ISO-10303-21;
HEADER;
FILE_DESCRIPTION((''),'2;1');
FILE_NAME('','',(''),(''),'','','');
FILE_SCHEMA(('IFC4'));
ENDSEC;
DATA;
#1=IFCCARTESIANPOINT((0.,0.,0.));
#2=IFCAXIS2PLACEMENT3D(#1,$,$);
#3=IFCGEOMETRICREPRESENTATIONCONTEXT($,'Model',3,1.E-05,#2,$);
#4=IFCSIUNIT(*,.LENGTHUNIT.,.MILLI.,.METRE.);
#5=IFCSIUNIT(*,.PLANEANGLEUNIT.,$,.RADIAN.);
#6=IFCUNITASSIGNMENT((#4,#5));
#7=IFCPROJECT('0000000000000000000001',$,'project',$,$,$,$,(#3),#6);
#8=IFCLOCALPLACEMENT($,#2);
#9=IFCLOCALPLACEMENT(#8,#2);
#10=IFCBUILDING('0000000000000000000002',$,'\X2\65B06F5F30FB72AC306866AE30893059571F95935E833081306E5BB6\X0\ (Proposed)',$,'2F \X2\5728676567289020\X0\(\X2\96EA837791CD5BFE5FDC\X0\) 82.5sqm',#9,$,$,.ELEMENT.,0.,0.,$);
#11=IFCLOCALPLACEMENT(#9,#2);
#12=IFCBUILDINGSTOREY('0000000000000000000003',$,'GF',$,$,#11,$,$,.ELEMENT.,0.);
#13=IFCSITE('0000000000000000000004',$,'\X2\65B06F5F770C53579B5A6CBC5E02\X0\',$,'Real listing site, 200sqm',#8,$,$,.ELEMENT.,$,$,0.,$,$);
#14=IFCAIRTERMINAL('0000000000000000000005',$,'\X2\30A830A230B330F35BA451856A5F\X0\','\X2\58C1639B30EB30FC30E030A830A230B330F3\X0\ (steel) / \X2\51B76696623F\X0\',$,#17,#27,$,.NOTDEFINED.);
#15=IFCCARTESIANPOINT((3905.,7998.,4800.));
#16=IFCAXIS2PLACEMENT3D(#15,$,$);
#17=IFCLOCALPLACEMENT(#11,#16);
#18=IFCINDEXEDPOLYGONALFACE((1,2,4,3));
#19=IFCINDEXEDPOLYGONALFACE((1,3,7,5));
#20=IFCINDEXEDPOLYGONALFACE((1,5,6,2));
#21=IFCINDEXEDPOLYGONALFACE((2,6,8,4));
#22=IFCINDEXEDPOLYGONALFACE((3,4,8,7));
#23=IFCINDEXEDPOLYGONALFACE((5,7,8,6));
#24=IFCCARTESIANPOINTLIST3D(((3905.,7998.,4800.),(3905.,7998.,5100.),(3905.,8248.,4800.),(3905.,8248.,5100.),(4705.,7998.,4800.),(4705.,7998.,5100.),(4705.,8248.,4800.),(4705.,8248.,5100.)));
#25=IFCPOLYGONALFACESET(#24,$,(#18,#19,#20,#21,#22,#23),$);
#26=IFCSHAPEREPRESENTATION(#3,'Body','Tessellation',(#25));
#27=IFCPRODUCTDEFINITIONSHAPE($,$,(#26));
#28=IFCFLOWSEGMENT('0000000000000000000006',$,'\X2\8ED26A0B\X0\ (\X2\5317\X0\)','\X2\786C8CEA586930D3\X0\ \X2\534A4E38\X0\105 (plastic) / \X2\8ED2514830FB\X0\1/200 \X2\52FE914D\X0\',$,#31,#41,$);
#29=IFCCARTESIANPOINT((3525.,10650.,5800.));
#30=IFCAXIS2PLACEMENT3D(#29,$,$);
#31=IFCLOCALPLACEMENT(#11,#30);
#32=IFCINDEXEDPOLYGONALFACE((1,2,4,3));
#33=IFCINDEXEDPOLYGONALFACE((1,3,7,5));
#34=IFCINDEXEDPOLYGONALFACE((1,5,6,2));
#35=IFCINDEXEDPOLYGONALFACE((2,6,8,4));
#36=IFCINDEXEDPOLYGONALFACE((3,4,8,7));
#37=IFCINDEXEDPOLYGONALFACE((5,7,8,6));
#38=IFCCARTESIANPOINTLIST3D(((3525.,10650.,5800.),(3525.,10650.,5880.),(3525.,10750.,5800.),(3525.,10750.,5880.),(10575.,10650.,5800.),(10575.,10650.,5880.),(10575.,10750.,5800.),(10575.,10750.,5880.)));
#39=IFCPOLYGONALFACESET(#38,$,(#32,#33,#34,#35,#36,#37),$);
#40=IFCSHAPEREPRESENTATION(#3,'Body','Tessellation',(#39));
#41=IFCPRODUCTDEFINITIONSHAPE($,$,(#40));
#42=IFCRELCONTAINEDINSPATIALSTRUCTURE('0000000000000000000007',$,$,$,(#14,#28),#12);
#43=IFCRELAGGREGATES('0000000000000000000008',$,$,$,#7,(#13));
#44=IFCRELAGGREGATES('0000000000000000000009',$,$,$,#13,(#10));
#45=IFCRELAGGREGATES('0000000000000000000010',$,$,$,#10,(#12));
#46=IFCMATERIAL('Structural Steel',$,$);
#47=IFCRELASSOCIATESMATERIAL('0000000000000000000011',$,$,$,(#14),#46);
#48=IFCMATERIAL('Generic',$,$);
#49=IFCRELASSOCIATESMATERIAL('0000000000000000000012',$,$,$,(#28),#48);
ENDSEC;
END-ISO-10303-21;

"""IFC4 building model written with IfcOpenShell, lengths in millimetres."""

from ifc_helpers import new_model, si_unit, frame, frame_2d, origin, place, context, project, spatial, rectangle, extrude, material, element, save


model = new_model("IFC4")

# Units and contexts
model_context = context("Model", 3, precision=1e-05, world=origin())
ifc_project = project(units=[si_unit("LENGTHUNIT", "METRE", prefix="MILLI"), si_unit("PLANEANGLEUNIT", "RADIAN")], contexts=[model_context])

# Site, building, storey
site_placement = place(None, origin())
site = spatial("IfcSite", under=ifc_project, at=site_placement, Name="新潟県南魚沼市", ObjectType="Real listing site, 200sqm", CompositionType="ELEMENT", RefElevation=0.0)
building_placement = place(site_placement, origin())
building = spatial("IfcBuilding", under=site, at=building_placement, Name="新潟・犬と暮らす土間広めの家 (Proposed)", ObjectType="2F 在来木造(雪荷重対応) 82.5sqm", CompositionType="ELEMENT", ElevationOfRefHeight=0.0, ElevationOfTerrain=0.0)
storey_placement = place(building_placement, origin())
storey = spatial("IfcBuildingStorey", under=building, at=storey_placement, Name="GF", CompositionType="ELEMENT", Elevation=0.0)

# Shared definitions
ifc_material_1 = material(Name="Structural Steel")

# Shared definitions
ifc_material_2 = material(Name="Generic")

# Air terminal
air_terminal_placement = place(storey_placement, frame((3905.0, 7998.0, 4800.0)))
element("IfcAirTerminal", 1, at=air_terminal_placement, inside=storey, material=ifc_material_1, Name="エアコン室内機", Description="壁掛ルームエアコン (steel) / 冷暖房", PredefinedType="NOTDEFINED", context=model_context, shape_type="SweptSolid", body=[
    extrude(rectangle(XDim=800.0, YDim=250.0, at=frame_2d((400.0, 125.0))), frame((3905.0, 7998.0, 4800.0)), (0.0, 0.0, 1.0), 300.0),
])

# Flow segment
flow_segment_placement = place(storey_placement, frame((3525.0, 10650.0, 5800.0)))
element("IfcFlowSegment", 2, at=flow_segment_placement, inside=storey, material=ifc_material_2, Name="軒樋 (北)", Description="硬質塩ビ 半丸105 (plastic) / 軒先・1/200 勾配", context=model_context, shape_type="SweptSolid", body=[
    extrude(rectangle(XDim=7050.0, YDim=100.0, at=frame_2d((3525.0, 50.0))), frame((3525.0, 10650.0, 5800.0)), (0.0, 0.0, 1.0), 80.0),
])

save(model, "model.ifc")
